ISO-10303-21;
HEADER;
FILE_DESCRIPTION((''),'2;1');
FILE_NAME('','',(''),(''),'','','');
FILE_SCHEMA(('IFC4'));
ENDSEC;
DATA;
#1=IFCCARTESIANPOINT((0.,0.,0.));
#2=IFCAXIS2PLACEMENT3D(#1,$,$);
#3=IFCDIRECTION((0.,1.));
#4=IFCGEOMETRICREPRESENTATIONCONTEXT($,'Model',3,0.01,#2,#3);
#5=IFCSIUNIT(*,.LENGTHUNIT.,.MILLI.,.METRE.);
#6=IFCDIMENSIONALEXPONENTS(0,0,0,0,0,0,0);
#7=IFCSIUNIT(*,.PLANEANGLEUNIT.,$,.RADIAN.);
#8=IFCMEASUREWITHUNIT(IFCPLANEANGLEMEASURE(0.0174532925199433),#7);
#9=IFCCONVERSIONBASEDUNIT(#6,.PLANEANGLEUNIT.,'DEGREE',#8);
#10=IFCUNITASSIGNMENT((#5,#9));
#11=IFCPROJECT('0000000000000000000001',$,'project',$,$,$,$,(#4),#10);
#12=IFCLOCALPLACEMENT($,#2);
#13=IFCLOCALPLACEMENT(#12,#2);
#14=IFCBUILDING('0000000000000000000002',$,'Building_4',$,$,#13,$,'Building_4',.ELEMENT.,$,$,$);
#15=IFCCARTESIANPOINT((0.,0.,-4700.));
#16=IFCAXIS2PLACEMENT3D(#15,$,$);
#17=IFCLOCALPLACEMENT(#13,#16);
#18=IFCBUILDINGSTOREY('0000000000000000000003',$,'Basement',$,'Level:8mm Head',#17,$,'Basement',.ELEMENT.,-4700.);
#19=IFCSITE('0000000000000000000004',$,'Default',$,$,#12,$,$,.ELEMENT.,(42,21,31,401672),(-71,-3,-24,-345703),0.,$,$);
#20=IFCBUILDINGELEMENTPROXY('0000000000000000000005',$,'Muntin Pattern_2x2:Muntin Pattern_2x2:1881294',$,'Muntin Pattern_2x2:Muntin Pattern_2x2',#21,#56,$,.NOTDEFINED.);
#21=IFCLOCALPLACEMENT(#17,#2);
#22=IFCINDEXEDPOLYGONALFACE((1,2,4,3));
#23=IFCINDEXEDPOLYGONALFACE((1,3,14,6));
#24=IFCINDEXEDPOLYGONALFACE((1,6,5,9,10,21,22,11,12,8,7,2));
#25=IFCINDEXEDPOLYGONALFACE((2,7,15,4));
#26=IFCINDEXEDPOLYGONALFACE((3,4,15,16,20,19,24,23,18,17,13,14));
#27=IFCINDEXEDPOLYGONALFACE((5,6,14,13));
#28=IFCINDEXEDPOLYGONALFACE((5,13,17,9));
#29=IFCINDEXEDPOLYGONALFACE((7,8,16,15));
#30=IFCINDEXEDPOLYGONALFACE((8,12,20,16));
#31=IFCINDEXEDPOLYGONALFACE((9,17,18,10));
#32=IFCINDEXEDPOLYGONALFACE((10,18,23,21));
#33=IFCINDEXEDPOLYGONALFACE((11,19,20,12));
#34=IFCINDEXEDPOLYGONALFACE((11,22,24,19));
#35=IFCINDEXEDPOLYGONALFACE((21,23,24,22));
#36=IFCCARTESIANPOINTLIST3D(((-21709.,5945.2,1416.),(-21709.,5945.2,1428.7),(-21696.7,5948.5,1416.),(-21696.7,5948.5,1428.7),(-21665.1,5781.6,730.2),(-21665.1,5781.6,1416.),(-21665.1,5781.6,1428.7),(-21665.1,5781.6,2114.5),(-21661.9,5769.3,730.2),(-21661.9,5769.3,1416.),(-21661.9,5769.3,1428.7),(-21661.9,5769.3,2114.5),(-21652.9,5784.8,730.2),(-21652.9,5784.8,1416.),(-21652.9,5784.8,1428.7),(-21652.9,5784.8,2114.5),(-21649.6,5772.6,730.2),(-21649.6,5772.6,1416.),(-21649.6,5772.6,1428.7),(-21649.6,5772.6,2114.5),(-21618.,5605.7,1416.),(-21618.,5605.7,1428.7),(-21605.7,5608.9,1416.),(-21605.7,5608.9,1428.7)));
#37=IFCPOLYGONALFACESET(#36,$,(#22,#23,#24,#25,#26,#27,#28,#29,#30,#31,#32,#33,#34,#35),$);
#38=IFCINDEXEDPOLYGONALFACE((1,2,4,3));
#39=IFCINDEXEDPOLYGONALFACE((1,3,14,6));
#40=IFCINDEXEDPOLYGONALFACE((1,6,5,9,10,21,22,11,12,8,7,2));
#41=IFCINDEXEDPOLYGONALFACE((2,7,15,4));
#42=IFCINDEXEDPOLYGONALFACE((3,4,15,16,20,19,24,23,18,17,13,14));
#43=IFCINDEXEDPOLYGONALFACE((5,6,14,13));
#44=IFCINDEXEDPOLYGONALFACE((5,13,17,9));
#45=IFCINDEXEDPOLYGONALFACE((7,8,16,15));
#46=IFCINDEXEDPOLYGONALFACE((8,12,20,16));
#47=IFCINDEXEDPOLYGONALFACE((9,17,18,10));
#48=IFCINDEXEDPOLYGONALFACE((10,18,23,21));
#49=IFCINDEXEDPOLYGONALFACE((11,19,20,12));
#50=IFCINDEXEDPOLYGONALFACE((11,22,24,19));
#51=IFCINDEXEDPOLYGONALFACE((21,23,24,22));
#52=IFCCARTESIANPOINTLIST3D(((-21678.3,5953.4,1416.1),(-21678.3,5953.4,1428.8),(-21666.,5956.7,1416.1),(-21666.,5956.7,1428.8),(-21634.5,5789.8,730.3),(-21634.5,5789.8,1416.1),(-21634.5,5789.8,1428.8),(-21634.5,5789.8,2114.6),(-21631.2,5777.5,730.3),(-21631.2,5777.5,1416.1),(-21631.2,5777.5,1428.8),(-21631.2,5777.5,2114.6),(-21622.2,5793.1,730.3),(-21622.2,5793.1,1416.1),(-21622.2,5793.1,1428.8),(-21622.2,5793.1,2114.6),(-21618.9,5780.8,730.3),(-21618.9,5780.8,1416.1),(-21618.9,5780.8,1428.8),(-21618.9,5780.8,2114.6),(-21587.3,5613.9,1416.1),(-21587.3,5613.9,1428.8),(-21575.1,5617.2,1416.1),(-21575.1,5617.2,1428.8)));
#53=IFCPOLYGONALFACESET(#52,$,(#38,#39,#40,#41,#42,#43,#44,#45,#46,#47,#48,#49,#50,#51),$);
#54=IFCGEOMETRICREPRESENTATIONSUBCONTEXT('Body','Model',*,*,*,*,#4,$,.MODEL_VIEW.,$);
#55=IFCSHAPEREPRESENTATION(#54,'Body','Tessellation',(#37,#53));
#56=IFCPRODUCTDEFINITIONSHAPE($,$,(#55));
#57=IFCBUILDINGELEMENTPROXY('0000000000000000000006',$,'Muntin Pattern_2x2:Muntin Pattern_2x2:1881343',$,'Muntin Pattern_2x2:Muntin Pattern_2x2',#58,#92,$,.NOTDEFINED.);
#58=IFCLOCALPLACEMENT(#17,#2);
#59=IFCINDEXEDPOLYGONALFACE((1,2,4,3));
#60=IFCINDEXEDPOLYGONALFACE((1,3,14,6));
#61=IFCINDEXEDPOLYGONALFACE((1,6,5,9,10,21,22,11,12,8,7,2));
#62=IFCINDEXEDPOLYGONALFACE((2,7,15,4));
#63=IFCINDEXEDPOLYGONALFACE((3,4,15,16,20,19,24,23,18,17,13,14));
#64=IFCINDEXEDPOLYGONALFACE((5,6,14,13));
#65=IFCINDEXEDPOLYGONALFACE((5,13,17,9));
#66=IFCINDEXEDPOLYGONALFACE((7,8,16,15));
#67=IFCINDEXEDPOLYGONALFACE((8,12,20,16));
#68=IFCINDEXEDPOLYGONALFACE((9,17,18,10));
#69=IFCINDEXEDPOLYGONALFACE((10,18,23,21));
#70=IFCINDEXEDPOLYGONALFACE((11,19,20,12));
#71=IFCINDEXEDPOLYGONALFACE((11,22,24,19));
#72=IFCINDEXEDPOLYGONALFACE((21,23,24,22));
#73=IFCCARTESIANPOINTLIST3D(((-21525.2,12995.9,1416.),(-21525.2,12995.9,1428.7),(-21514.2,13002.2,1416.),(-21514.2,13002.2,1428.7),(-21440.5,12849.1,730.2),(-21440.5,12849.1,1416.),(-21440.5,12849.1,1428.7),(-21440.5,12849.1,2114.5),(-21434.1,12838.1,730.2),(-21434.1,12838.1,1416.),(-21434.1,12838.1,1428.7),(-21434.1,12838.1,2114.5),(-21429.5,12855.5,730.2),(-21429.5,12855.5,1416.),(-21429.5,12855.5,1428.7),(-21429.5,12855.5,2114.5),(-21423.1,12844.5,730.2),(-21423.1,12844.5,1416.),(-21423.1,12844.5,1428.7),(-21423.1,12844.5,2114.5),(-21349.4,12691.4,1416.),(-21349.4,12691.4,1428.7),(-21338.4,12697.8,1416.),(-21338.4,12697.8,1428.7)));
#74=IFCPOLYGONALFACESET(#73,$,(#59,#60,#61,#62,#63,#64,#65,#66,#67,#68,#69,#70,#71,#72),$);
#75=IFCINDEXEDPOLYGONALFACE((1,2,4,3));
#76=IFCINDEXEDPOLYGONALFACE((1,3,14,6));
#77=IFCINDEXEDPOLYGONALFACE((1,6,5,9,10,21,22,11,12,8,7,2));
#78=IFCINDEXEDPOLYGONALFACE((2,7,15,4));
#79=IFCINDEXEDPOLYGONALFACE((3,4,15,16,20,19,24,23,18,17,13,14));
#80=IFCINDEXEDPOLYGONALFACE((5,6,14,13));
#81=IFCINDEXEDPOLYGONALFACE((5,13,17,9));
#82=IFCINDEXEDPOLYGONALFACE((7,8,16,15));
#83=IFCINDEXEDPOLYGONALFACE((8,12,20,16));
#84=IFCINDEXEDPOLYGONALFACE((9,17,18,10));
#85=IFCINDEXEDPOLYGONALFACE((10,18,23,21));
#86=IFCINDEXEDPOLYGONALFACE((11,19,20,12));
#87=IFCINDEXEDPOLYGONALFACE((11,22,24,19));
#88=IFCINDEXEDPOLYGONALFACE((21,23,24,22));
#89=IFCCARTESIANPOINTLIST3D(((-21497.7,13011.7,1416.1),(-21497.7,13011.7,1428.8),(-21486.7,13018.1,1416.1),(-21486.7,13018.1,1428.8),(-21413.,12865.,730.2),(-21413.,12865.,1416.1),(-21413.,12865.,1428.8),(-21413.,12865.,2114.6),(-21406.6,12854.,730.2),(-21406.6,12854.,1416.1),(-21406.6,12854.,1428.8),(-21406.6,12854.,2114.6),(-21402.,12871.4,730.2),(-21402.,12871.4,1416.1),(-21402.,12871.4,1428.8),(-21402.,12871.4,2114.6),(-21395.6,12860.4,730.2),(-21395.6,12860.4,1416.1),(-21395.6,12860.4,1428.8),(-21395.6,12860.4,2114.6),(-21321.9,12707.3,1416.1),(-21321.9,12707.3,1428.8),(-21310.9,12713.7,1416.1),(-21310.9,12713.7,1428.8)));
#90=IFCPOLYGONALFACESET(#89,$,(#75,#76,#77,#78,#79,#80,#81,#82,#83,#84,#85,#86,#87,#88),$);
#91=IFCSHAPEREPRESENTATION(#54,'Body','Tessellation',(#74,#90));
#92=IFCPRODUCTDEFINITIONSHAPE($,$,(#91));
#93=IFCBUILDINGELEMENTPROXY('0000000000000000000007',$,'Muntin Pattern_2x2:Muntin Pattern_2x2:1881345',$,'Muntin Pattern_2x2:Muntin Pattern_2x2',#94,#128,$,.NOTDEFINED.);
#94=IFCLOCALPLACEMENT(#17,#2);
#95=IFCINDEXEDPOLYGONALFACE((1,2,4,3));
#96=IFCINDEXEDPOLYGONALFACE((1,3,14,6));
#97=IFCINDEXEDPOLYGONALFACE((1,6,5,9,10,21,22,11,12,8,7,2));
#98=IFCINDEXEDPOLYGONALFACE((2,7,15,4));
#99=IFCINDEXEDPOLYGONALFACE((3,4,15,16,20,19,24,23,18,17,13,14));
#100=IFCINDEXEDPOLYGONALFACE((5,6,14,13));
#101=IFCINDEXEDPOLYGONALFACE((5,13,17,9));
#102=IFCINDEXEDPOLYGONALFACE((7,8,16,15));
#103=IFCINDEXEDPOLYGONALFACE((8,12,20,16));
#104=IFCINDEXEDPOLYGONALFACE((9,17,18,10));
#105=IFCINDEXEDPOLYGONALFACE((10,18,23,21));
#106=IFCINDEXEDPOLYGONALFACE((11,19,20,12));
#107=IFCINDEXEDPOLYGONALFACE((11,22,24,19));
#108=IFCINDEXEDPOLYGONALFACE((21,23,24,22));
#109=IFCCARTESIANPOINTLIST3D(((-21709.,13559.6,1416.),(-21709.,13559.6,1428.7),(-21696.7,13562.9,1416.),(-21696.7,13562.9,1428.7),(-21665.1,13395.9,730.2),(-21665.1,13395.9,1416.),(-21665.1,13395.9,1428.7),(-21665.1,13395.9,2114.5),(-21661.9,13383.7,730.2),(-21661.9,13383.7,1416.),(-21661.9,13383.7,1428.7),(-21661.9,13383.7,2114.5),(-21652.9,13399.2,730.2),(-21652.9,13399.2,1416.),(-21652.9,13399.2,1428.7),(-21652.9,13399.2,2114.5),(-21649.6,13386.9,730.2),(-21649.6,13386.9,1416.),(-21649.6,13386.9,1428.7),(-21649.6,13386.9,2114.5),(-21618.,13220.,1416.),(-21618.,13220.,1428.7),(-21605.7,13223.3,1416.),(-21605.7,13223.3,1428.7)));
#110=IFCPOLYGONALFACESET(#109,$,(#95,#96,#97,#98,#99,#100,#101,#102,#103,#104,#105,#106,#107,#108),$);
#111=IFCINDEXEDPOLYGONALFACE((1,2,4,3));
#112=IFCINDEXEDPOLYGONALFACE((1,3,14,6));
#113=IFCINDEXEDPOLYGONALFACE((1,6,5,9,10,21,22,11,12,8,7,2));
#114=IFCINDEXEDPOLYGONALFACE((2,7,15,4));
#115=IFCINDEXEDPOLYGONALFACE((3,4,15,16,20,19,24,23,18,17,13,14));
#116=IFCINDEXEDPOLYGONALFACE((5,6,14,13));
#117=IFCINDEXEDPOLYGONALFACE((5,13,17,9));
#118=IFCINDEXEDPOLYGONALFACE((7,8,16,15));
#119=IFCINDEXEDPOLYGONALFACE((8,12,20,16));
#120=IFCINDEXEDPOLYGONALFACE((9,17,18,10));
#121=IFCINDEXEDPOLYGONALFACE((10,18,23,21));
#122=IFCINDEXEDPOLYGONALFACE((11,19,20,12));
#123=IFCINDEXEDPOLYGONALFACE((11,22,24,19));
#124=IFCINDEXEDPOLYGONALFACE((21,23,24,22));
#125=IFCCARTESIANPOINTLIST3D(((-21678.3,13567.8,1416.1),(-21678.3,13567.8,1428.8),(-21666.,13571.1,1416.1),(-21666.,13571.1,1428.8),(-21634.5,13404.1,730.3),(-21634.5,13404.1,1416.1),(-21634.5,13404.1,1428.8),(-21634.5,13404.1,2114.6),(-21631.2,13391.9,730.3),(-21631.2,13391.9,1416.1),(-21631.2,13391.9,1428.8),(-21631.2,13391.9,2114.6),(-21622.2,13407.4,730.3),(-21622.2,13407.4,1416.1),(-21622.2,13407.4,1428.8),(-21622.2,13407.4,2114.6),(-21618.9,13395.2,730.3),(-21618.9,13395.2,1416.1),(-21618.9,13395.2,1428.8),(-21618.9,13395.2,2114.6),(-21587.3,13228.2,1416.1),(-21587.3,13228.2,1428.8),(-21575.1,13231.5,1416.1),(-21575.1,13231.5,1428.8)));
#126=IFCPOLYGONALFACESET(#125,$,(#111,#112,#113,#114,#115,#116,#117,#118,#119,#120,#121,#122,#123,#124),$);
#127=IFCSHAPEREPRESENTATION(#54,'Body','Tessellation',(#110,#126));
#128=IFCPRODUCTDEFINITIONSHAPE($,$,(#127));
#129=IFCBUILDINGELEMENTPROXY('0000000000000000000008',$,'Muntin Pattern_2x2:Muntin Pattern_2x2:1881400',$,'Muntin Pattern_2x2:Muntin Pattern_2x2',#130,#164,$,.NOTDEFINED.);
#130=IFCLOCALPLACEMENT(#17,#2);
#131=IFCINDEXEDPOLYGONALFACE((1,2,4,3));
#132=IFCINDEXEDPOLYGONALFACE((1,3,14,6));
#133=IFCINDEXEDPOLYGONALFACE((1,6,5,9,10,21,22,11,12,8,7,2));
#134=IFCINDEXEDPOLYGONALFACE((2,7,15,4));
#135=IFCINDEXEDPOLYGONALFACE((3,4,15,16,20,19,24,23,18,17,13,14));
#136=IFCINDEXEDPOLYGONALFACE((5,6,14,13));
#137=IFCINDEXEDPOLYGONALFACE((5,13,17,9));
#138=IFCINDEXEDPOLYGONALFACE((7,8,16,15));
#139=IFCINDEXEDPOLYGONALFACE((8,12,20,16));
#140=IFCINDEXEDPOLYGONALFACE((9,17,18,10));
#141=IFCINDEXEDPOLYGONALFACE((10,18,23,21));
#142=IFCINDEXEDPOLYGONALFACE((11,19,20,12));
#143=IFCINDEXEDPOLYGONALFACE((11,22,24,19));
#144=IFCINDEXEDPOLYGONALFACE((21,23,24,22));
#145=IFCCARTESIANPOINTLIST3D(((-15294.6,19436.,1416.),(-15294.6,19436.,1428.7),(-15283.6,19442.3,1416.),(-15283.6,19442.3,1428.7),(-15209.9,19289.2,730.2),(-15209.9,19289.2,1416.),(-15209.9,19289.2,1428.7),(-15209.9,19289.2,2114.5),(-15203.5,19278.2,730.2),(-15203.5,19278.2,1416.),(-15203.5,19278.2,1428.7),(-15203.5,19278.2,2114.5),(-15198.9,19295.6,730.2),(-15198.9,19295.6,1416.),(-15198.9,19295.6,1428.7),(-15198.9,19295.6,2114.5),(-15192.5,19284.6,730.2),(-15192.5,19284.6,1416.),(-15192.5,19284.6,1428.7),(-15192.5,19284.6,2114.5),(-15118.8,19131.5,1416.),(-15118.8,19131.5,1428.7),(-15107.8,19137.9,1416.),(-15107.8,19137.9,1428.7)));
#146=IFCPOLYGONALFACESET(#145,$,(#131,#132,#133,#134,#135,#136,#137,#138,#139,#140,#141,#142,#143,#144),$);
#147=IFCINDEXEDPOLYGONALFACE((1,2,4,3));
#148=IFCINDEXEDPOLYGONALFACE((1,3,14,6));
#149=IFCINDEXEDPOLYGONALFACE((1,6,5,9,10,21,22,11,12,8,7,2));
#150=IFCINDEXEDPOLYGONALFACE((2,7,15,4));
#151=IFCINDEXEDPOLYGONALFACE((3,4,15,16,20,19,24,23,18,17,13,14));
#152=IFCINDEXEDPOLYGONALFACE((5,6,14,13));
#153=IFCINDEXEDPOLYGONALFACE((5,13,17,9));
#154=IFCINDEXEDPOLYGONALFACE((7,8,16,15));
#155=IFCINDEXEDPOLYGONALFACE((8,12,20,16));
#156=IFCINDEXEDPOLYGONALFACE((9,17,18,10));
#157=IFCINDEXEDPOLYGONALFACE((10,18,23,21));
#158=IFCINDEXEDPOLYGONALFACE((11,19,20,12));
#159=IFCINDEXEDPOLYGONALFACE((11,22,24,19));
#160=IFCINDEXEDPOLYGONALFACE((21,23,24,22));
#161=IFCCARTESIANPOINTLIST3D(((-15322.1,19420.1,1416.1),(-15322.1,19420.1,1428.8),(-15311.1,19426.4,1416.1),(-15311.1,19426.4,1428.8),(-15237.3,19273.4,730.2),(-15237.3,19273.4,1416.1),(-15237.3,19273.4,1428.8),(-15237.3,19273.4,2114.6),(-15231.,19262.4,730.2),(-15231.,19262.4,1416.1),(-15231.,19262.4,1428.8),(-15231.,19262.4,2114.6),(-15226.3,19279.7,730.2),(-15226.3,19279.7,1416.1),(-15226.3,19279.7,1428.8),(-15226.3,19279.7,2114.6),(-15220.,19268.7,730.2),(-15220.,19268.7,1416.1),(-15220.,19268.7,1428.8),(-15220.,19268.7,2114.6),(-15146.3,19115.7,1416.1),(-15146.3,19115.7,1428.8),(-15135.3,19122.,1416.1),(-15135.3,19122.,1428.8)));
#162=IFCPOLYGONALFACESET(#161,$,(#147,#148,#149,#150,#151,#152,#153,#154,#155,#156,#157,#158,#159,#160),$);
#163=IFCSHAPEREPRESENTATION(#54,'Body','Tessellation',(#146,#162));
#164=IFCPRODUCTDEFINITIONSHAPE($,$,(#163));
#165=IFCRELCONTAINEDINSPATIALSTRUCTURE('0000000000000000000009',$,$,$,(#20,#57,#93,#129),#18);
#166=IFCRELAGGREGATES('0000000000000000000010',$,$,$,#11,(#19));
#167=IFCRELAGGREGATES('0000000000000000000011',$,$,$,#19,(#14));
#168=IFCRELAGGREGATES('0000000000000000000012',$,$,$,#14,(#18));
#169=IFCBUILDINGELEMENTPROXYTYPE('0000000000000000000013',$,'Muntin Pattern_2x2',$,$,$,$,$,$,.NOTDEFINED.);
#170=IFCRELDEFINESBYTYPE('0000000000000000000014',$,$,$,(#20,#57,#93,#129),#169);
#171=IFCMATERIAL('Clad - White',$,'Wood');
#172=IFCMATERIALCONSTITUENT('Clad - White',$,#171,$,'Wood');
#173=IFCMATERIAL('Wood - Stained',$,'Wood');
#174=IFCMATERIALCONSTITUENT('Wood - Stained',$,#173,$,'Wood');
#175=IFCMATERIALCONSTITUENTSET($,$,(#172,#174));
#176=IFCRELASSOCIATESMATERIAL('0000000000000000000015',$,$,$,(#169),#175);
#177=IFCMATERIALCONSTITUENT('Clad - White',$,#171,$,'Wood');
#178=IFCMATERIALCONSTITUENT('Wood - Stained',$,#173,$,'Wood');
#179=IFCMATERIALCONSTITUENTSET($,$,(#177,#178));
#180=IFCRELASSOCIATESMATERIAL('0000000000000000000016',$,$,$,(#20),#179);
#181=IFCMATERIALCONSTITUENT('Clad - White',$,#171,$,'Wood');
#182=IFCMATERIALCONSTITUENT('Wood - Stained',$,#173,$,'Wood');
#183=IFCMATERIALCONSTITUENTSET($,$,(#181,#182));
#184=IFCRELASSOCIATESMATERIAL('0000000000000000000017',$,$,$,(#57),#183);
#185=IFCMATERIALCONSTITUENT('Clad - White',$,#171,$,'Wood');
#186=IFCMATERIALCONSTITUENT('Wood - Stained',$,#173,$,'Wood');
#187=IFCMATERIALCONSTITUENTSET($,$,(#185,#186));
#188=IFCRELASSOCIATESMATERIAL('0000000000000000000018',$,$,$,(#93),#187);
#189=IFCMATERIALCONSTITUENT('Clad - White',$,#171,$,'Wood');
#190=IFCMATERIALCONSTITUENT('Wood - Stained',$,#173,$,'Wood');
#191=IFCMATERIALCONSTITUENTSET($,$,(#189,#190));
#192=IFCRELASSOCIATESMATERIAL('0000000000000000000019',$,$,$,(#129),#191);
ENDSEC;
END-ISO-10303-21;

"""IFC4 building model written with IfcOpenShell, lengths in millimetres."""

from ifc_helpers import new_model, entity, si_unit, converted_unit, direction, frame, origin, place, context, subcontext, project, spatial, indexed_curve, outline, extrude, source, transform, mapped, material, constituent, constituent_set, type_object, type_shapes, element, save


model = new_model("IFC4")

# Units and contexts
model_context = context("Model", 3, precision=0.01, world=origin(), true_north=direction((0.0, 1.0)))
body_context = subcontext(model_context, "Body", "Model", "MODEL_VIEW")
ifc_project = project(units=[si_unit("LENGTHUNIT", "METRE", prefix="MILLI"), converted_unit("PLANEANGLEUNIT", "DEGREE", entity("IfcPlaneAngleMeasure", 0.0174532925199433), si_unit("PLANEANGLEUNIT", "RADIAN"), dimensions=[0, 0, 0, 0, 0, 0, 0])], contexts=[model_context])

# Site, building, storey
site_placement = place(None, origin())
site = spatial("IfcSite", under=ifc_project, at=site_placement, Name="Default", CompositionType="ELEMENT", RefLatitude=(42, 21, 31, 401672), RefLongitude=(-71, -3, -24, -345703), RefElevation=0.0)
building_placement = place(site_placement, origin())
building = spatial("IfcBuilding", under=site, at=building_placement, Name="Building_4", LongName="Building_4", CompositionType="ELEMENT")
storey_placement = place(building_placement, frame((0.0, 0.0, -4700.0)))
storey = spatial("IfcBuildingStorey", under=building, at=storey_placement, Name="Basement", ObjectType="Level:8mm Head", LongName="Basement", CompositionType="ELEMENT", Elevation=-4700.0)

# Building element proxies
ifc_material_1 = material(Name="Clad - White", Category="Wood")
ifc_material_2 = material(Name="Wood - Stained", Category="Wood")
ifc_constituent_1 = constituent(ifc_material_1, Name="Clad - White", Category="Wood")
ifc_constituent_2 = constituent(ifc_material_2, Name="Wood - Stained", Category="Wood")
ifc_constituent_set_1 = constituent_set(constituents=[ifc_constituent_1, ifc_constituent_2])
building_element_proxy_type_1 = type_object("IfcBuildingElementProxyType", Name="Muntin Pattern_2x2", PredefinedType="NOTDEFINED", material=ifc_constituent_set_1)
shared_shape_1 = source(origin(), body_context, "Body", "SweptSolid", [
    extrude(outline(indexed_curve([(6.4, -6.4), (692.1, -6.4), (692.1, 6.3), (6.4, 6.3), (6.4, 175.8), (-6.3, 175.8), (-6.3, 6.3), (-692.2, 6.3), (-692.2, -6.4), (-6.3, -6.4), (-6.3, -175.8), (6.4, -175.8), (6.4, -6.4)], self_intersect=False)), frame((0.0, 9.5, 692.1), z_axis=(0.0, 1.0, 0.0), x_axis=(0.0, 0.0, 1.0)), (0.0, 0.0, 1.0), 12.7),
    extrude(outline(indexed_curve([(6.4, -6.4), (692.1, -6.4), (692.1, 6.3), (6.4, 6.3), (6.4, 175.8), (-6.3, 175.8), (-6.3, 6.3), (-692.2, 6.3), (-692.2, -6.4), (-6.3, -6.4), (-6.3, -175.8), (6.4, -175.8), (6.4, -6.4)], self_intersect=False)), frame((0.0, -22.2, 692.2), z_axis=(0.0, 1.0, 0.0), x_axis=(0.0, 0.0, 1.0)), (0.0, 0.0, 1.0), 12.7),
])
type_shapes(building_element_proxy_type_1, [shared_shape_1])
ifc_constituent_3 = constituent(ifc_material_1, Name="Clad - White", Category="Wood")
ifc_constituent_4 = constituent(ifc_material_2, Name="Wood - Stained", Category="Wood")
ifc_constituent_set_2 = constituent_set(constituents=[ifc_constituent_3, ifc_constituent_4])
proxy_1_placement = place(storey_placement, frame((-21642.0, 5781.2, 730.3), z_axis=(0.0, 0.0, 1.0), x_axis=(-0.258819, 0.965926, 0.0)))
element("IfcBuildingElementProxy", 1, at=proxy_1_placement, inside=storey, type_object=building_element_proxy_type_1, material=ifc_constituent_set_2, Name="Muntin Pattern_2x2:Muntin Pattern_2x2:1881294", ObjectType="Muntin Pattern_2x2:Muntin Pattern_2x2", PredefinedType="NOTDEFINED", context=body_context, shape_type="MappedRepresentation", body=[
    mapped(shared_shape_1, transform((0.0, 0.0, 0.0), scale=1.0)),
])
ifc_constituent_5 = constituent(ifc_material_1, Name="Clad - White", Category="Wood")
ifc_constituent_6 = constituent(ifc_material_2, Name="Wood - Stained", Category="Wood")
ifc_constituent_set_3 = constituent_set(constituents=[ifc_constituent_5, ifc_constituent_6])
proxy_2_placement = place(storey_placement, frame((-21418.0, 12854.8, 730.2), z_axis=(0.0, 0.0, 1.0), x_axis=(-0.5, 0.866025, 0.0)))
element("IfcBuildingElementProxy", 2, at=proxy_2_placement, inside=storey, type_object=building_element_proxy_type_1, material=ifc_constituent_set_3, Name="Muntin Pattern_2x2:Muntin Pattern_2x2:1881343", ObjectType="Muntin Pattern_2x2:Muntin Pattern_2x2", PredefinedType="NOTDEFINED", context=body_context, shape_type="MappedRepresentation", body=[
    mapped(shared_shape_1, transform((0.0, 0.0, 0.0), scale=1.0)),
])
ifc_constituent_7 = constituent(ifc_material_1, Name="Clad - White", Category="Wood")
ifc_constituent_8 = constituent(ifc_material_2, Name="Wood - Stained", Category="Wood")
ifc_constituent_set_4 = constituent_set(constituents=[ifc_constituent_7, ifc_constituent_8])
proxy_3_placement = place(storey_placement, frame((-21642.0, 13395.5, 730.3), z_axis=(0.0, 0.0, 1.0), x_axis=(-0.258819, 0.965926, 0.0)))
element("IfcBuildingElementProxy", 3, at=proxy_3_placement, inside=storey, type_object=building_element_proxy_type_1, material=ifc_constituent_set_4, Name="Muntin Pattern_2x2:Muntin Pattern_2x2:1881345", ObjectType="Muntin Pattern_2x2:Muntin Pattern_2x2", PredefinedType="NOTDEFINED", context=body_context, shape_type="MappedRepresentation", body=[
    mapped(shared_shape_1, transform((0.0, 0.0, 0.0), scale=1.0)),
])
ifc_constituent_9 = constituent(ifc_material_1, Name="Clad - White", Category="Wood")
ifc_constituent_10 = constituent(ifc_material_2, Name="Wood - Stained", Category="Wood")
ifc_constituent_set_5 = constituent_set(constituents=[ifc_constituent_9, ifc_constituent_10])
proxy_4_placement = place(storey_placement, frame((-15214.9, 19279.0, 730.2), z_axis=(0.0, 0.0, 1.0), x_axis=(0.5, -0.866025, 0.0)))
element("IfcBuildingElementProxy", 4, at=proxy_4_placement, inside=storey, type_object=building_element_proxy_type_1, material=ifc_constituent_set_5, Name="Muntin Pattern_2x2:Muntin Pattern_2x2:1881400", ObjectType="Muntin Pattern_2x2:Muntin Pattern_2x2", PredefinedType="NOTDEFINED", context=body_context, shape_type="MappedRepresentation", body=[
    mapped(shared_shape_1, transform((0.0, 0.0, 0.0), scale=1.0)),
])

save(model, "model.ifc")
